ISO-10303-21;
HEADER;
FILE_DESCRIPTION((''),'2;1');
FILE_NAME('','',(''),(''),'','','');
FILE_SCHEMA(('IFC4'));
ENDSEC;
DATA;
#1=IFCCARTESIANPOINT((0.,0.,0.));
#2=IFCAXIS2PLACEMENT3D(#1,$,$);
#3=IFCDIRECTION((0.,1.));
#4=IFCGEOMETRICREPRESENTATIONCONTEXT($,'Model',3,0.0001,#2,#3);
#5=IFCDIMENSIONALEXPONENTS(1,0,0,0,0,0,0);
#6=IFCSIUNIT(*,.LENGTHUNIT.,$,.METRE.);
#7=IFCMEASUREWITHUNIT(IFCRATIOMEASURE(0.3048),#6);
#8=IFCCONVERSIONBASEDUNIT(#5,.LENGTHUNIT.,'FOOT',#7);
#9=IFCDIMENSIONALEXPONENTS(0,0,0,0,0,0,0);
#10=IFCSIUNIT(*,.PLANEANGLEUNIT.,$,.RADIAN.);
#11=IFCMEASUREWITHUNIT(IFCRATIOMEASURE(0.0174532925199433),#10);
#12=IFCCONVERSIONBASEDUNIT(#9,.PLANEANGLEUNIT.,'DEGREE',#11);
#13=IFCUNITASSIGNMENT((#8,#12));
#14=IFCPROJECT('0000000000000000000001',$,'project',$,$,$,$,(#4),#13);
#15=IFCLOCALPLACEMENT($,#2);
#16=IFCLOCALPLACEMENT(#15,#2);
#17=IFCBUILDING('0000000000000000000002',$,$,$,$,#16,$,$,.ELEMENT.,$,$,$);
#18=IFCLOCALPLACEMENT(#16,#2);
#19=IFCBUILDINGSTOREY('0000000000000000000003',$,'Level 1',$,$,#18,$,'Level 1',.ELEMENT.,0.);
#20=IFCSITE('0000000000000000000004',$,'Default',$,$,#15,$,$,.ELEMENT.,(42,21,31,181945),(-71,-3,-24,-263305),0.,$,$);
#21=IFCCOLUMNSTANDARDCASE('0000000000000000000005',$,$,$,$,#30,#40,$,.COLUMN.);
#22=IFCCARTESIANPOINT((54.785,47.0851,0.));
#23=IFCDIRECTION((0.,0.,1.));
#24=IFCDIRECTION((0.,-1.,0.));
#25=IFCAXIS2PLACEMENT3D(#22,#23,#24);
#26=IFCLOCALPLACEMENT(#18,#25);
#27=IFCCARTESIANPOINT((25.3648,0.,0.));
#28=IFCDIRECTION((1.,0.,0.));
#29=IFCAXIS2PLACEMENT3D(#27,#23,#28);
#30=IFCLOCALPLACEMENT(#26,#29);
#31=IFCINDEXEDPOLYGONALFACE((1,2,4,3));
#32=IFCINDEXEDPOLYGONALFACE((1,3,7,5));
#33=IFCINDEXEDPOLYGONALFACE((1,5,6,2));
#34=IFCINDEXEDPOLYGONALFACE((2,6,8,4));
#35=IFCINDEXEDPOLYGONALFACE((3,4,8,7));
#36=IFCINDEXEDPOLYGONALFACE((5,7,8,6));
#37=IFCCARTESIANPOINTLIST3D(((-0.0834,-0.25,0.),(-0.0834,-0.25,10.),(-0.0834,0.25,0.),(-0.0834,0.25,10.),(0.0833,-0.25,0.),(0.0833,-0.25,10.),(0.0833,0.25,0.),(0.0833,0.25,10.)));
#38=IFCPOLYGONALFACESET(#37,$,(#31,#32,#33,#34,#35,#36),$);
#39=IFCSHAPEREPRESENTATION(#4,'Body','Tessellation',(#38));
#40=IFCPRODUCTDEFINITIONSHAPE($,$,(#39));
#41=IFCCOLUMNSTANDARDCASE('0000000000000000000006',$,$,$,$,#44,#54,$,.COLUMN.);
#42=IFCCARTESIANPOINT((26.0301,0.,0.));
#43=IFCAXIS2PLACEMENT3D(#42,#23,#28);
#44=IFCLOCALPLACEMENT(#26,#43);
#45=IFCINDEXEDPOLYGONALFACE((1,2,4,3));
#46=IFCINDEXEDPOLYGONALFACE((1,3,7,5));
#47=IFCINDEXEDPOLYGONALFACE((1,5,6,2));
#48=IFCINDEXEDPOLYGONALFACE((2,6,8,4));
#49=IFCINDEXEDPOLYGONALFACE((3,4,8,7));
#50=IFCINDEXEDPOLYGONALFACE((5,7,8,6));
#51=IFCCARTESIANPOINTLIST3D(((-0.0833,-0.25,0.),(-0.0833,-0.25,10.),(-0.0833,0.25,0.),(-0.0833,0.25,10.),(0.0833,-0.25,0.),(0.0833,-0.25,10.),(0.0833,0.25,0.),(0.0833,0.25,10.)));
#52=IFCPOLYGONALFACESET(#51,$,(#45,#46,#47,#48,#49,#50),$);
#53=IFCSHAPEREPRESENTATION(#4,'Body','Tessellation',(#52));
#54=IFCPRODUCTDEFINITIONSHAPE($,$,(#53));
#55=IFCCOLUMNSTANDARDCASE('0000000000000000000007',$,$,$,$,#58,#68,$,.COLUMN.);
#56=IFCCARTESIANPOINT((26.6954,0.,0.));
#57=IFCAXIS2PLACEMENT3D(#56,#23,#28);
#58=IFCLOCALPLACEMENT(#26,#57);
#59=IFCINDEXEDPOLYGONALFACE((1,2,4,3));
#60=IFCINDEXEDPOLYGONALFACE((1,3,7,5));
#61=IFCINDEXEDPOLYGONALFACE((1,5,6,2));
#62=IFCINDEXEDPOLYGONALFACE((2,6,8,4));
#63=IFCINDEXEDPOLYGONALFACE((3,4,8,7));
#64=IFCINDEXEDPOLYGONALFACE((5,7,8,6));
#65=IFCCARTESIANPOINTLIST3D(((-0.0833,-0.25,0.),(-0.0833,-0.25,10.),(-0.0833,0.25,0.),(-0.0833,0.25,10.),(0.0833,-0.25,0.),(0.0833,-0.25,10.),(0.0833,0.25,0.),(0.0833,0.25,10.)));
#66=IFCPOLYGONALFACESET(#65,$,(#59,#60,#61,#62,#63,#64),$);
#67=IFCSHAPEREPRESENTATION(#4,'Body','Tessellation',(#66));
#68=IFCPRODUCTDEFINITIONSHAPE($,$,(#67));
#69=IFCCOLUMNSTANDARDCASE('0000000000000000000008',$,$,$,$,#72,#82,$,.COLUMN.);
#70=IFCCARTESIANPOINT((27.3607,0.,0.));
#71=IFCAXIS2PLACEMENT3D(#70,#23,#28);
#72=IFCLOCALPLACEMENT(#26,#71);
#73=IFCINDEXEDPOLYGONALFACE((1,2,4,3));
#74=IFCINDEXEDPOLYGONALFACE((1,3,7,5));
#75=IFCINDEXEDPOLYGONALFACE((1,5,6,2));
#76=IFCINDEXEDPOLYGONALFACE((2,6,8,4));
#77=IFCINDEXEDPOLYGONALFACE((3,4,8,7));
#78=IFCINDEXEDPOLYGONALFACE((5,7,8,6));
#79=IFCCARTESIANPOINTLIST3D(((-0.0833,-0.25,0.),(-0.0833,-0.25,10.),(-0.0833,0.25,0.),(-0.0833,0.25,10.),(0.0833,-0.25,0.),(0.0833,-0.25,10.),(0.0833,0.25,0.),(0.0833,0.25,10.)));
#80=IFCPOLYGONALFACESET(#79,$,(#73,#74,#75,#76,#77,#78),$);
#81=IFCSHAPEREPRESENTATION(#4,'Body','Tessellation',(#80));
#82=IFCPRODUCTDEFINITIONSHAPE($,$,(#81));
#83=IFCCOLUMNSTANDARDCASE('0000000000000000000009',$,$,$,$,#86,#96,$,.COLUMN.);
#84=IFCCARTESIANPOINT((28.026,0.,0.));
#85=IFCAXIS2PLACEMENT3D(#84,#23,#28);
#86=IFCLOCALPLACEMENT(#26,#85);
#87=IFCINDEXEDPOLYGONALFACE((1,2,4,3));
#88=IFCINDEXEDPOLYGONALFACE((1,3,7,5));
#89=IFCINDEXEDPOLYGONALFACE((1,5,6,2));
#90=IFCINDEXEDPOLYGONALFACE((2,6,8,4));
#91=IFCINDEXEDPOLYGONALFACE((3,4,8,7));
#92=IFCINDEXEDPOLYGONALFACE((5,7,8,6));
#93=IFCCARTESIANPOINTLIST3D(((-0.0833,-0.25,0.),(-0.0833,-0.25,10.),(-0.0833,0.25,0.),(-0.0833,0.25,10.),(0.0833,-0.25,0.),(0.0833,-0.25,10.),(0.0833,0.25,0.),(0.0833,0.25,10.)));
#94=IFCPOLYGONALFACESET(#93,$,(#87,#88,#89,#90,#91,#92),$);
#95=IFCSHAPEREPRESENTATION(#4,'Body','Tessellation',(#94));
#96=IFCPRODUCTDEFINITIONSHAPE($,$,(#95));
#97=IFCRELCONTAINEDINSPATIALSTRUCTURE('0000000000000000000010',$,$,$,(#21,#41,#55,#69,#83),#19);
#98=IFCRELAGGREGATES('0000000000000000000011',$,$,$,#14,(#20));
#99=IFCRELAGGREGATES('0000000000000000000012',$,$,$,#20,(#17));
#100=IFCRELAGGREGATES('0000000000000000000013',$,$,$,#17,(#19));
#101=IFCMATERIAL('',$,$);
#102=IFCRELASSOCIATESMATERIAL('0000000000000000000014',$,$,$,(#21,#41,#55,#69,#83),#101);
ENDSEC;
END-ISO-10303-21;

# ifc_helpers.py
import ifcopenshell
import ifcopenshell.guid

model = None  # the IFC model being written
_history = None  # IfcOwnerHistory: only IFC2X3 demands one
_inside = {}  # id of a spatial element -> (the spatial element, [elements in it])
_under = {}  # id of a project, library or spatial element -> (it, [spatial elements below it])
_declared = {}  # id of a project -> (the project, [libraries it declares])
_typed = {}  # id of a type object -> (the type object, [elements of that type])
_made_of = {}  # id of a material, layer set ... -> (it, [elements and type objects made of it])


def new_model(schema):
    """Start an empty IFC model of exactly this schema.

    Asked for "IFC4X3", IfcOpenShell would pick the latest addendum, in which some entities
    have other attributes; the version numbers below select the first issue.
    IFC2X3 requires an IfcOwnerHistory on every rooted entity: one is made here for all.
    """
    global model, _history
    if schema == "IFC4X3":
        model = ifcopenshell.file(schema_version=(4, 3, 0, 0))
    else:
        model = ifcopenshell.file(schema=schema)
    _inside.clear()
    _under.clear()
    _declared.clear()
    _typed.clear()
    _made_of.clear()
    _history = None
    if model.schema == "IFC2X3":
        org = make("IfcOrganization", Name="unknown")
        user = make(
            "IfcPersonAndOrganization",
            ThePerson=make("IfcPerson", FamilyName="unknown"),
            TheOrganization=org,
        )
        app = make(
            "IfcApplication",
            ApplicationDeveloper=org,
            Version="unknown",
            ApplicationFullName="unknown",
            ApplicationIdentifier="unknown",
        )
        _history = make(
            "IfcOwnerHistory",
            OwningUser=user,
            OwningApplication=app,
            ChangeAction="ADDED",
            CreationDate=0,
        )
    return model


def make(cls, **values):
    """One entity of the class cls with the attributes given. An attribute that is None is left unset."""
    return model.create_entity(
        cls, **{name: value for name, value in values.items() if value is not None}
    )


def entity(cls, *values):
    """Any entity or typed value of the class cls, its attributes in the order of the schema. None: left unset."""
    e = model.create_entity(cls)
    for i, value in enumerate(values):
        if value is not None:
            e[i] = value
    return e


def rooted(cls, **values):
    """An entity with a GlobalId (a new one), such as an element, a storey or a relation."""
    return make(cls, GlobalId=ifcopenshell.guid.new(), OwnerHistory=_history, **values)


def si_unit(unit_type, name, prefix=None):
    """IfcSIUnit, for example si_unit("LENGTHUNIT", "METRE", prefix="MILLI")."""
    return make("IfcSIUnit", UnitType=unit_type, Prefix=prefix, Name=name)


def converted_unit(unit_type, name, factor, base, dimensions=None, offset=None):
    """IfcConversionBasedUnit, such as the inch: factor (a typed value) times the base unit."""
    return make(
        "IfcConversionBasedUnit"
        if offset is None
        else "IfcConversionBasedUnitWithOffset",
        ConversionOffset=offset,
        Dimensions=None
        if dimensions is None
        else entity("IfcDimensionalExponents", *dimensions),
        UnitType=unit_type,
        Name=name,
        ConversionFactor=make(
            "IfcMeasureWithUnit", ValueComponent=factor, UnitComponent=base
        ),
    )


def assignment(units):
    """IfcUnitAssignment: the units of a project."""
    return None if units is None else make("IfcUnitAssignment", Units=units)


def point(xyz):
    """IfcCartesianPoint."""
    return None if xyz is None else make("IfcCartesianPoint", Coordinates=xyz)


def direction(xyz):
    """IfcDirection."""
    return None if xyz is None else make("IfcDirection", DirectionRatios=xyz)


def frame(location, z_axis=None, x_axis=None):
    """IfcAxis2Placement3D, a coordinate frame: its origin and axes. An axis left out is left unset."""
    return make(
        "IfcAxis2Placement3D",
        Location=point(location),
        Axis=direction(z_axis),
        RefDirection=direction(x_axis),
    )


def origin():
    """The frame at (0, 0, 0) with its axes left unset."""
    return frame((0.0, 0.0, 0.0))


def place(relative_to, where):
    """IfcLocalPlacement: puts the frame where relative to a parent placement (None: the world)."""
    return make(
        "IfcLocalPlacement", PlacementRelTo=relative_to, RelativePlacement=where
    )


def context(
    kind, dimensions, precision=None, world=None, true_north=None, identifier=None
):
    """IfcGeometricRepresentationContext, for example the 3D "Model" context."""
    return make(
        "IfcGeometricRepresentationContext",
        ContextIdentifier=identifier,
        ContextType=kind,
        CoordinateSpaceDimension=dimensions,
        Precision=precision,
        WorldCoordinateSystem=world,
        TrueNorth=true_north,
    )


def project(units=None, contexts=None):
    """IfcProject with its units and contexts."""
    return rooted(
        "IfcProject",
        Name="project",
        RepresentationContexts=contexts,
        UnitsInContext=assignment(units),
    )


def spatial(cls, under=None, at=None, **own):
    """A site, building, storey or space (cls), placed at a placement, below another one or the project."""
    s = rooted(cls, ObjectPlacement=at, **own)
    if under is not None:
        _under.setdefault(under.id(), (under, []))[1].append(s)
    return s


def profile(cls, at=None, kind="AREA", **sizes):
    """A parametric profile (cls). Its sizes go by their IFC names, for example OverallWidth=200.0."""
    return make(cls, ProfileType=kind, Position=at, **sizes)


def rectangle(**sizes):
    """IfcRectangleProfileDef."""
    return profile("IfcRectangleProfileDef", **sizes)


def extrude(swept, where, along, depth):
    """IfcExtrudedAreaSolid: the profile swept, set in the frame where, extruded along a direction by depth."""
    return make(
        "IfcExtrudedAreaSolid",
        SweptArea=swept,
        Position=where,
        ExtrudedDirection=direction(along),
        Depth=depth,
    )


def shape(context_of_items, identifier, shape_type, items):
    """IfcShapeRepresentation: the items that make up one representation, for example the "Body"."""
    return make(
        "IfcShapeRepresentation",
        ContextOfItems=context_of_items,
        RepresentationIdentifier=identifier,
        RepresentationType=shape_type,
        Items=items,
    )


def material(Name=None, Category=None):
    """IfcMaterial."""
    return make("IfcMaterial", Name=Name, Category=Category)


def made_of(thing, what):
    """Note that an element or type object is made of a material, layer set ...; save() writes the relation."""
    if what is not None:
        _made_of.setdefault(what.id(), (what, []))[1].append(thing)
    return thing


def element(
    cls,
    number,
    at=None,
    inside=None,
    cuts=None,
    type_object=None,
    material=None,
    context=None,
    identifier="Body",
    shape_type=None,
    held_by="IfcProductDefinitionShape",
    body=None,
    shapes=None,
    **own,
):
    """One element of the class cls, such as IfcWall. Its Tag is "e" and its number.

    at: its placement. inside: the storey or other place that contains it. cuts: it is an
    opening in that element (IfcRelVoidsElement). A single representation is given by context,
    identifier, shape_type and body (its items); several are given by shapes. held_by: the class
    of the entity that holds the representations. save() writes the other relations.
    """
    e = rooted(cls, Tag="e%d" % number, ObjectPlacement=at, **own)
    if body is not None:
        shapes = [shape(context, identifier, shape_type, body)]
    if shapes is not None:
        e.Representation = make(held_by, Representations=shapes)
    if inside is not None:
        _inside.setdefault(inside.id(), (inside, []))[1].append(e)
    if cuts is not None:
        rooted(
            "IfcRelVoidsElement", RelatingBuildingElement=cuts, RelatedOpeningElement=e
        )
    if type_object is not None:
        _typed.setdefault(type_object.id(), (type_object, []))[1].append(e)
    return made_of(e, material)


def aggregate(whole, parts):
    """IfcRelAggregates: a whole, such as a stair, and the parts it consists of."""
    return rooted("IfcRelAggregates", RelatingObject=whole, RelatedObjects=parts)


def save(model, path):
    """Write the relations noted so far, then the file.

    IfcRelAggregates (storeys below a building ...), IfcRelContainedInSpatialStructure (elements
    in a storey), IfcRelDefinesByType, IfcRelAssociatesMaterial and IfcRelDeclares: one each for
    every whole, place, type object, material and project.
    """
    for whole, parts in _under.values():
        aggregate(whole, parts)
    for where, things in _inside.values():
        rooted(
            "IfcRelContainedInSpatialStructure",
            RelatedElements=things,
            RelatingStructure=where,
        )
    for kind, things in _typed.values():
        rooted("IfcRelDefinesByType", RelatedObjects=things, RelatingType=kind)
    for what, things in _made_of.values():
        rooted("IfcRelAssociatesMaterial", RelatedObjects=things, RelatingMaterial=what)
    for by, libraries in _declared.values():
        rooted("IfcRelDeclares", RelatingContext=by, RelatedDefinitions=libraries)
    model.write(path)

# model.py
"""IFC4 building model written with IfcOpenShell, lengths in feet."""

from ifc_helpers import new_model, entity, si_unit, converted_unit, direction, frame, origin, place, context, project, spatial, rectangle, extrude, material, element, save


model = new_model("IFC4")

# Units and contexts
model_context = context("Model", 3, precision=0.0001, world=origin(), true_north=direction((0.0, 1.0)))
ifc_project = project(units=[converted_unit("LENGTHUNIT", "FOOT", entity("IfcRatioMeasure", 0.3048), si_unit("LENGTHUNIT", "METRE"), dimensions=[1, 0, 0, 0, 0, 0, 0]), converted_unit("PLANEANGLEUNIT", "DEGREE", entity("IfcRatioMeasure", 0.0174532925199433), si_unit("PLANEANGLEUNIT", "RADIAN"), dimensions=[0, 0, 0, 0, 0, 0, 0])], contexts=[model_context])

# Site, building, storey
site_placement = place(None, origin())
site = spatial("IfcSite", under=ifc_project, at=site_placement, Name="Default", CompositionType="ELEMENT", RefLatitude=(42, 21, 31, 181945), RefLongitude=(-71, -3, -24, -263305), RefElevation=0.0)
building_placement = place(site_placement, origin())
building = spatial("IfcBuilding", under=site, at=building_placement, CompositionType="ELEMENT")
storey_placement = place(building_placement, origin())
storey = spatial("IfcBuildingStorey", under=building, at=storey_placement, Name="Level 1", LongName="Level 1", CompositionType="ELEMENT", Elevation=0.0)

# Columns
ifc_material = material(Name="")
placement = place(storey_placement, frame((54.785, 47.0851, 0.0), z_axis=(0.0, 0.0, 1.0), x_axis=(0.0, -1.0, 0.0)))
for number, where, z_axis, x_axis in (
    (1, (25.3648, 0.0, 0.0), (0.0, 0.0, 1.0), (1.0, 0.0, 0.0)),
    (2, (26.0301, 0.0, 0.0), (0.0, 0.0, 1.0), (1.0, 0.0, 0.0)),
    (3, (26.6954, 0.0, 0.0), (0.0, 0.0, 1.0), (1.0, 0.0, 0.0)),
    (4, (27.3607, 0.0, 0.0), (0.0, 0.0, 1.0), (1.0, 0.0, 0.0)),
    (5, (28.026, 0.0, 0.0), (0.0, 0.0, 1.0), (1.0, 0.0, 0.0)),
):
    element("IfcColumnStandardCase", number, at=place(placement, frame(where, z_axis=z_axis, x_axis=x_axis)), inside=storey, material=ifc_material, PredefinedType="COLUMN", context=model_context, shape_type="SweptSolid", body=[
        extrude(rectangle(XDim=0.1667, YDim=0.5), origin(), (0.0, 0.0, 1.0), 10.0),
    ])

save(model, "model.ifc")
